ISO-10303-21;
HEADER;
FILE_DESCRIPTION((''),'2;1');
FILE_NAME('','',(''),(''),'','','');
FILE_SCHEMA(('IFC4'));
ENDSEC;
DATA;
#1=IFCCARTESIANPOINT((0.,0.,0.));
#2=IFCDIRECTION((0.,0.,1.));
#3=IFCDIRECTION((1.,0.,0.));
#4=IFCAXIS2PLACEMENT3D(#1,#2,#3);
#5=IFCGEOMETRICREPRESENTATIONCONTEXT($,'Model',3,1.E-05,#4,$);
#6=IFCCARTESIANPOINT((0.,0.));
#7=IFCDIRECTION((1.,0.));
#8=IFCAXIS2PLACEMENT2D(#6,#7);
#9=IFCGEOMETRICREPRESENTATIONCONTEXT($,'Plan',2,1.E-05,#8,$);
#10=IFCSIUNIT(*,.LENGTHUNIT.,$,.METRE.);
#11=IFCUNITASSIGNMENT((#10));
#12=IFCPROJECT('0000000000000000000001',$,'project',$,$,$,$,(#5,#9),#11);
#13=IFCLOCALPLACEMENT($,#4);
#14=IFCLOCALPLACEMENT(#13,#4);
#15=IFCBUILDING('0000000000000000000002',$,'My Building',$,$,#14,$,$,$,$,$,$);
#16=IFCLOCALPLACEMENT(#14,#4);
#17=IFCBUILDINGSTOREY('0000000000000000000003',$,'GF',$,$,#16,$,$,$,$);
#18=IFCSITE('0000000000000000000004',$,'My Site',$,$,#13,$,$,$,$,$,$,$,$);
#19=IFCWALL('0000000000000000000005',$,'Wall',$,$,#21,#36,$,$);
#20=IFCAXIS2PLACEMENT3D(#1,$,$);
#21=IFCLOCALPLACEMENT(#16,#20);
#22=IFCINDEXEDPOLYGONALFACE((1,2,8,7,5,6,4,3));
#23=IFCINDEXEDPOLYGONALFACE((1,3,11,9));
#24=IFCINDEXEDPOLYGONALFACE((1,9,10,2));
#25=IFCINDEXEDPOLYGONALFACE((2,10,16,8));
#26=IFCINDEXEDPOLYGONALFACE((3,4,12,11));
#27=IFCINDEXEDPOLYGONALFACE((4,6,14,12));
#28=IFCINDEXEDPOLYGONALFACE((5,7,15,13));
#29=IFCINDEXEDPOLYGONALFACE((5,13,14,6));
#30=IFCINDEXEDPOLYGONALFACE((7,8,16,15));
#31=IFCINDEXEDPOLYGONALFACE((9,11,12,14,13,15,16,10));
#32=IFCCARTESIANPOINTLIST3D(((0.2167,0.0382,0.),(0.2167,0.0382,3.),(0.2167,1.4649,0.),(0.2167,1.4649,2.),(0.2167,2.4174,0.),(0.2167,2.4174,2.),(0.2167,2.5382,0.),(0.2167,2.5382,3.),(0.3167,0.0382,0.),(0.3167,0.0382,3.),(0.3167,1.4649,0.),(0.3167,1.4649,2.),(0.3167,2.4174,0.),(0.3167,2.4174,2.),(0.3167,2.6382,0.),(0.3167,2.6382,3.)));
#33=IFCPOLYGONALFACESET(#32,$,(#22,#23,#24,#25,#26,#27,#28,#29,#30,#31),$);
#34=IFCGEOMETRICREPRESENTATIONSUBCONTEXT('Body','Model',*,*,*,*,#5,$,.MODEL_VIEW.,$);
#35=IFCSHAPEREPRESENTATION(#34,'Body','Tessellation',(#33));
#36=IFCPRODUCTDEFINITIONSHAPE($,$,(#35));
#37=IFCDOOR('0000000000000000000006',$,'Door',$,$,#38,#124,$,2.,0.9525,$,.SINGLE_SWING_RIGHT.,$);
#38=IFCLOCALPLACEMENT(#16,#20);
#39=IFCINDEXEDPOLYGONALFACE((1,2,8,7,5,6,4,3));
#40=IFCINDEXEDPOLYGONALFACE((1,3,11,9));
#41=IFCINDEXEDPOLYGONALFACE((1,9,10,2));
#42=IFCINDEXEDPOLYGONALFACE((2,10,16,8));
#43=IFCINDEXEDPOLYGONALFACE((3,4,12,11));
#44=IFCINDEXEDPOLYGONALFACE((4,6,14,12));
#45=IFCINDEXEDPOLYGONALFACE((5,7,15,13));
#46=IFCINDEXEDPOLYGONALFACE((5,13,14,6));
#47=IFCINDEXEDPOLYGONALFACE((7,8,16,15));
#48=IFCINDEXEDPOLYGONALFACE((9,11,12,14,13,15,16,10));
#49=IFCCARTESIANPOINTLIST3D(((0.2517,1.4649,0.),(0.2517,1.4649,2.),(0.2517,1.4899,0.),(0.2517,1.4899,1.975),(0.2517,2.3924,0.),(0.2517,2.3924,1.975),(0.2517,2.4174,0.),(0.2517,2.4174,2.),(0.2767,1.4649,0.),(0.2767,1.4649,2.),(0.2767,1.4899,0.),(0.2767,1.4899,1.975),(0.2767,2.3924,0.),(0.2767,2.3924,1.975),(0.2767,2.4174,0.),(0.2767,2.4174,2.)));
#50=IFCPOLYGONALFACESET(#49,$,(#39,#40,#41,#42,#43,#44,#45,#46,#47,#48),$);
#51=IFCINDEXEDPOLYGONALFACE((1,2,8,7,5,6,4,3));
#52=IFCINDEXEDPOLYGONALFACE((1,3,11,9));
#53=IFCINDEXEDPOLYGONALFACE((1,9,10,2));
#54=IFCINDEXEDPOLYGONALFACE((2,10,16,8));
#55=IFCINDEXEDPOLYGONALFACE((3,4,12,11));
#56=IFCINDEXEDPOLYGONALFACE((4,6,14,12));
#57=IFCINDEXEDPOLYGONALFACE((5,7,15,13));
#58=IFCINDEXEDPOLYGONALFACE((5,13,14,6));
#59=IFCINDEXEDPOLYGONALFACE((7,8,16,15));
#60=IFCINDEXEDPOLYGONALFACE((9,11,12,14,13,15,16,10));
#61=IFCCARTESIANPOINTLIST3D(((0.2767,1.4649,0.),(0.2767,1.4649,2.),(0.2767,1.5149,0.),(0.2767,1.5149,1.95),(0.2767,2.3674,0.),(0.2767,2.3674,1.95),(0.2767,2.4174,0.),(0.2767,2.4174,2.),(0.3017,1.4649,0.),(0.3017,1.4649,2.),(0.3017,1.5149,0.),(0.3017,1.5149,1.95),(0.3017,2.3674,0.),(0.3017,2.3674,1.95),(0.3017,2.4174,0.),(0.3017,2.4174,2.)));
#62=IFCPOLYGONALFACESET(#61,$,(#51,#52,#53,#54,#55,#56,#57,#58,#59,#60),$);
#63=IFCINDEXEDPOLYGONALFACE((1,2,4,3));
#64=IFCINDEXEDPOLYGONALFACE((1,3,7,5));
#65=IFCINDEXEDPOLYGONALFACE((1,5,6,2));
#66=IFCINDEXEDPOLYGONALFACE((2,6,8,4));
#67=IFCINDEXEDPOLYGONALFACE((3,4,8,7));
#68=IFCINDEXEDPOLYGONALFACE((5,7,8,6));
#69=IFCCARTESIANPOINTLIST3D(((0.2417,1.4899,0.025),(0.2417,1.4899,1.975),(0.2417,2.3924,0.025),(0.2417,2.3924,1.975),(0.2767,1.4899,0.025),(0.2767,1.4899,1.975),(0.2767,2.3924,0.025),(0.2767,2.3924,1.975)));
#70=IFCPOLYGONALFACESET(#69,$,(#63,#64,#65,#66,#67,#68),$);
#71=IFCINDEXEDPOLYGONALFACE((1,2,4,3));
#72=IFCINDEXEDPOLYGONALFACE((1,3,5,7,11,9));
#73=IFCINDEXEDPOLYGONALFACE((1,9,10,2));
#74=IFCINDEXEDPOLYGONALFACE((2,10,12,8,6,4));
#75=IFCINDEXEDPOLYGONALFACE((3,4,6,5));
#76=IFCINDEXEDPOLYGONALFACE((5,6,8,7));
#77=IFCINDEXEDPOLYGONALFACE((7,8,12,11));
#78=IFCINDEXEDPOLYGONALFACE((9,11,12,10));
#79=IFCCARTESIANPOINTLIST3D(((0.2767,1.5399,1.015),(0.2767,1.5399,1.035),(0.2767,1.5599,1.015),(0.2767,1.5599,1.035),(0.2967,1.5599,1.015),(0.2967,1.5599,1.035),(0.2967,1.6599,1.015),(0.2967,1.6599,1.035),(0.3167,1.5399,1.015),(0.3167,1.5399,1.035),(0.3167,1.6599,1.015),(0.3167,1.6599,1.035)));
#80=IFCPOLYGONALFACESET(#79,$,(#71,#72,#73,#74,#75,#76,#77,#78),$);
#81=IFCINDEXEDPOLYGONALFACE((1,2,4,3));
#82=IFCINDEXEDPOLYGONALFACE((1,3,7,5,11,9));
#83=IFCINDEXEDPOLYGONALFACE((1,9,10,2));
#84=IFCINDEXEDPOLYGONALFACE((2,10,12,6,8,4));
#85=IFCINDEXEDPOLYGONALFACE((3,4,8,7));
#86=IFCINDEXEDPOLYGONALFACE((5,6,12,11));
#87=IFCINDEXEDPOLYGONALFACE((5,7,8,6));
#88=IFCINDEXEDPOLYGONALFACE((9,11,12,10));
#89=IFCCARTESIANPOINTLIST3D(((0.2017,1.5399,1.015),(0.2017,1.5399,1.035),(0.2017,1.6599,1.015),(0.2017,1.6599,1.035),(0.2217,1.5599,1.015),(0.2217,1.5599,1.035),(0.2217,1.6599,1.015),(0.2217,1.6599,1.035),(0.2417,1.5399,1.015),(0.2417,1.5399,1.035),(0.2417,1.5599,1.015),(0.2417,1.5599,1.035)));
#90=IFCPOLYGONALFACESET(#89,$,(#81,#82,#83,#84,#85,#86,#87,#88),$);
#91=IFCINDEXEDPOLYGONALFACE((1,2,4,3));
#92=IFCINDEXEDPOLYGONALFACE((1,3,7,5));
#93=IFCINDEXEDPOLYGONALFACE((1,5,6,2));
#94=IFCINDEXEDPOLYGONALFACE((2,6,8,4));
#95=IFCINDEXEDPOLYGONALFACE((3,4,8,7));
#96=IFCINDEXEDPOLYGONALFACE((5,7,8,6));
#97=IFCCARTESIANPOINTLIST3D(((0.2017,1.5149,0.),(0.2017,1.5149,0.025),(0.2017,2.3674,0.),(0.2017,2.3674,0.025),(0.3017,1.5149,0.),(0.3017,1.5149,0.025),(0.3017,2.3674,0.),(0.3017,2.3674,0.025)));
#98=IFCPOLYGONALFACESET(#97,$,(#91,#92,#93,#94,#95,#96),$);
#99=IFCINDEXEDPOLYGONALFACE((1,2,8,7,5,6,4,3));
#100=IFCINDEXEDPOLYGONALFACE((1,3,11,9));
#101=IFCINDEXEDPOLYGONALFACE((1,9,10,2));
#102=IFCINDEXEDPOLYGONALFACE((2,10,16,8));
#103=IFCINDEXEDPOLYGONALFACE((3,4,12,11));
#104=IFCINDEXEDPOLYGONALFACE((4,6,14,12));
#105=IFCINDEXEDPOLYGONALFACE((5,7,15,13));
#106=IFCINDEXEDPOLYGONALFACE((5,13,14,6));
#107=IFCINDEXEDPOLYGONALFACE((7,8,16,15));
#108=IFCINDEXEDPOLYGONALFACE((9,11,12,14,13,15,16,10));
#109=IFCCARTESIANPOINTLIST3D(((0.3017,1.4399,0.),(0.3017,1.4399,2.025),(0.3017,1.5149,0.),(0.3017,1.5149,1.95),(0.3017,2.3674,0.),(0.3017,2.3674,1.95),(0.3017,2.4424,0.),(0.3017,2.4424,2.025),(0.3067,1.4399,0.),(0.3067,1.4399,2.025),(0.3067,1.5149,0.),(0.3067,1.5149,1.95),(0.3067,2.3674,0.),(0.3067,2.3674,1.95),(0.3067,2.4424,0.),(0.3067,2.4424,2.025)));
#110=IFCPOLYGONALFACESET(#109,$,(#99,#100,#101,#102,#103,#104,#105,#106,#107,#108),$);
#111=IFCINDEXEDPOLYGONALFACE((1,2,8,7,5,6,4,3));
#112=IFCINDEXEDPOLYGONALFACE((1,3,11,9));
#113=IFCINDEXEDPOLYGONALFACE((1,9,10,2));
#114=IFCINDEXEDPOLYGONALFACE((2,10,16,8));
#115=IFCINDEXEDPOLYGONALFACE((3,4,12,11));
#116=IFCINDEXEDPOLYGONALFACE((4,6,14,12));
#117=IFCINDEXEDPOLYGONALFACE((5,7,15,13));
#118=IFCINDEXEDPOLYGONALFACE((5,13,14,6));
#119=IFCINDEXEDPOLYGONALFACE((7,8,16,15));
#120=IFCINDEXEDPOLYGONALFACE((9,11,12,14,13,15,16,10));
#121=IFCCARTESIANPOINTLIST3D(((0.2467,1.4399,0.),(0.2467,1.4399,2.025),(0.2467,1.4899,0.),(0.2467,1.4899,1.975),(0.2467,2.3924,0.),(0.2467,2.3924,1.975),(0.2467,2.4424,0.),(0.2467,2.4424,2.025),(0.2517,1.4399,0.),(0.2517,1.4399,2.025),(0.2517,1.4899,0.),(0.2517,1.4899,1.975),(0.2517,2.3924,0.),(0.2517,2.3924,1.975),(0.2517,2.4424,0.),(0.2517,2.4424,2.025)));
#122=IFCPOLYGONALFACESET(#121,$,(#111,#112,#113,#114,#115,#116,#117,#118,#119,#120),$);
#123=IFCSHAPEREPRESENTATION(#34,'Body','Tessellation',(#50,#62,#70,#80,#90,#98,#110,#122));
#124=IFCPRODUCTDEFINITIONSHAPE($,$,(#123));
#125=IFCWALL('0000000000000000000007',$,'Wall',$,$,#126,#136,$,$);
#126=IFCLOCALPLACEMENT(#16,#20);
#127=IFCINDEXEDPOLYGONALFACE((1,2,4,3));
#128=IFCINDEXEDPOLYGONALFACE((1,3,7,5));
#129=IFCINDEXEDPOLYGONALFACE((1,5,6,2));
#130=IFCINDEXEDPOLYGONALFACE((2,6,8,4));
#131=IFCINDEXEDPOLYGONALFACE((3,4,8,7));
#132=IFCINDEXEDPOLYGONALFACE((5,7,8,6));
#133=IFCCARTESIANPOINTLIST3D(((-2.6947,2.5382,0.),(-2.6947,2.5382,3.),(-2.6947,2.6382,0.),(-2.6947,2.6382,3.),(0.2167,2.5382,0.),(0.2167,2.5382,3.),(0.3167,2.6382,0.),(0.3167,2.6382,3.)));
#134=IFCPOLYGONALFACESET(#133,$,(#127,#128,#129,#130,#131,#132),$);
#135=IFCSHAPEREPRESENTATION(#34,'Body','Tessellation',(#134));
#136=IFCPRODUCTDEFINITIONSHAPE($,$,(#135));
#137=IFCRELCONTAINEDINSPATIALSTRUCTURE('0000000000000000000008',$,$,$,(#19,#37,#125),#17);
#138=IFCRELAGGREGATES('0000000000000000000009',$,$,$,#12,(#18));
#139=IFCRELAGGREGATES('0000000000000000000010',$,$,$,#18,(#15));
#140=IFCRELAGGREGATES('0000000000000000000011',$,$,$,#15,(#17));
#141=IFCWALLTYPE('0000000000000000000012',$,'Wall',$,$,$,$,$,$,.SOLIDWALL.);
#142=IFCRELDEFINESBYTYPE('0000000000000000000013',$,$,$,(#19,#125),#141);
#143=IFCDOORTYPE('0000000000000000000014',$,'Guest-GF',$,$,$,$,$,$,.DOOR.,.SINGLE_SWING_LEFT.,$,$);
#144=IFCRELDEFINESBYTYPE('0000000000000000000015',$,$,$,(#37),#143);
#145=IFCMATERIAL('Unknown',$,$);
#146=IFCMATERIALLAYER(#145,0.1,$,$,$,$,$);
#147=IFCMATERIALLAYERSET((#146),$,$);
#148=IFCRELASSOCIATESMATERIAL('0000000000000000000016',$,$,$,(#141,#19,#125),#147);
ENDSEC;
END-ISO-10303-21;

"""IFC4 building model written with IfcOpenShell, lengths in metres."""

from ifc_helpers import new_model, entity, si_unit, frame, origin_with_axes, origin_2d_with_axis, place, context, subcontext, project, spatial, line, indexed_curve, outline, extrude, shape, source, transform, mapped, material, layer, layer_set, layer_usage, type_object, type_shapes, element, fill, save


model = new_model("IFC4")

# Units and contexts
model_context = context("Model", 3, precision=1e-05, world=origin_with_axes())
plan_context = context("Plan", 2, precision=1e-05, world=origin_2d_with_axis())
body_context_1 = subcontext(model_context, "Body", "Model", "MODEL_VIEW")
body_context_2 = subcontext(plan_context, "Body", "Plan", "PLAN_VIEW")
ifc_project = project(units=[si_unit("LENGTHUNIT", "METRE")], contexts=[model_context, plan_context])

# Site, building, storey
site_placement = place(None, origin_with_axes())
site = spatial("IfcSite", under=ifc_project, at=site_placement, Name="My Site")
building_placement = place(site_placement, origin_with_axes())
building = spatial("IfcBuilding", under=site, at=building_placement, Name="My Building")
storey_placement = place(building_placement, origin_with_axes())
storey = spatial("IfcBuildingStorey", under=building, at=storey_placement, Name="GF")

# Shared definitions
ifc_material_1 = material(Name="Unknown")

# Shared definitions
ifc_layer_1 = layer(ifc_material_1, 0.1)
ifc_layer_set_1 = layer_set([ifc_layer_1])
wall_type = type_object("IfcWallType", Name="Wall", PredefinedType="SOLIDWALL", material=ifc_layer_set_1)

# Wall, opening, door
ifc_layer_usage_1 = layer_usage(ifc_layer_set_1, "AXIS2", "POSITIVE", 0.0)
wall_1_placement = place(storey_placement, frame((0.3167, 0.0382, 0.0), z_axis=(0.0, 0.0, 1.0), x_axis=(0.0, 1.0, 0.0)))
wall_1 = element("IfcWall", 1, at=wall_1_placement, inside=storey, type_object=wall_type, material=ifc_layer_usage_1, Name="Wall", context=body_context_1, shape_type="SweptSolid", body=[
    extrude(outline(indexed_curve([(0.0, 0.0), (0.0, 0.1), (2.5, 0.1), (2.6, 0.0)], segments=[line(1, 2, 3, 4, 1)])), origin_with_axes(), (0.0, 0.0, 1.0), 3.0),
])
shared_shape_1 = source(origin_with_axes(), body_context_1, "Body", "SweptSolid", [
    extrude(outline(indexed_curve([(0.0, 0.0), (0.9525, 0.0), (0.9525, 2.0), (0.0, 2.0)], segments=[line(1, 2, 3, 4, 1)])), frame((0.0, -0.6, 0.0), z_axis=(0.0, -1.0, 0.0), x_axis=(1.0, 0.0, 0.0)), (0.0, 0.0, -1.0), 1.2),
])
opening_1_placement = place(wall_1_placement, frame((1.4267, 0.015, 0.0), z_axis=(0.0, 0.0, 1.0), x_axis=(1.0, 0.0, 0.0)))
opening_1 = element("IfcOpeningElement", 2, at=opening_1_placement, cuts=wall_1, PredefinedType="OPENING", context=body_context_1, shape_type="MappedRepresentation", body=[
    mapped(shared_shape_1, transform((0.0, 0.0, 0.0), x_axis=(1.0, 0.0, 0.0), y_axis=(0.0, 1.0, 0.0), z_axis=(0.0, 0.0, 1.0), scale=1.0)),
])
door_type_1 = type_object("IfcDoorType", Name="Guest-GF", OperationType="SINGLE_SWING_LEFT", PredefinedType="DOOR")
shared_shape_2 = source(origin_with_axes(), body_context_1, "Body", "SweptSolid", [
    extrude(outline(indexed_curve([(0.0, 0.0), (0.0, 2.0), (0.9525, 2.0), (0.9525, 0.0), (0.9275, 0.0), (0.9275, 1.975), (0.025, 1.975), (0.025, 0.0)], segments=[line(1, 2, 3, 4, 5, 6, 7, 8, 1)])), frame((0.0, 0.025, 0.0), z_axis=(0.0, -1.0, 0.0), x_axis=(1.0, 0.0, 0.0)), (0.0, 0.0, -1.0), 0.025),
    extrude(outline(indexed_curve([(0.0, 0.0), (0.0, 2.0), (0.9525, 2.0), (0.9525, 0.0), (0.9025, 0.0), (0.9025, 1.95), (0.05, 1.95), (0.05, 0.0)], segments=[line(1, 2, 3, 4, 5, 6, 7, 8, 1)])), frame((0.0, 0.0, 0.0), z_axis=(0.0, -1.0, 0.0), x_axis=(1.0, 0.0, 0.0)), (0.0, 0.0, -1.0), 0.025),
    extrude(outline(indexed_curve([(0.0, 0.0), (0.9025, 0.0), (0.9025, 0.035), (0.0, 0.035)], segments=[line(1, 2, 3, 4, 1)])), frame((0.025, 0.025, 0.025), z_axis=(0.0, 0.0, 1.0), x_axis=(1.0, 0.0, 0.0)), (0.0, 0.0, 1.0), 1.95),
    extrude(outline(indexed_curve([(0.0, 0.0), (0.0, -0.04), (0.12, -0.04), (0.12, -0.02), (0.02, -0.02), (0.02, 0.0)], segments=[line(1, 2, 3, 4, 5, 6, 1)])), frame((0.075, 0.025, 1.015), z_axis=(0.0, 0.0, 1.0), x_axis=(1.0, 0.0, 0.0)), (0.0, 0.0, 1.0), 0.02),
    extrude(outline(indexed_curve([(0.0, 0.0), (0.0, 0.04), (0.12, 0.04), (0.12, 0.02), (0.02, 0.02), (0.02, 0.0)], segments=[line(1, 2, 3, 4, 5, 6, 1)])), frame((0.075, 0.06, 1.015), z_axis=(0.0, 0.0, 1.0), x_axis=(1.0, 0.0, 0.0)), (0.0, 0.0, 1.0), 0.02),
    extrude(outline(indexed_curve([(0.0, 0.0), (0.8525, 0.0), (0.8525, 0.1), (0.0, 0.1)], segments=[line(1, 2, 3, 4, 1)])), frame((0.05, 0.0, 0.0), z_axis=(0.0, 0.0, 1.0), x_axis=(1.0, 0.0, 0.0)), (0.0, 0.0, 1.0), 0.025),
    extrude(outline(indexed_curve([(0.0, 0.0), (0.0, 2.025), (1.0025, 2.025), (1.0025, 0.0), (0.9275, 0.0), (0.9275, 1.95), (0.075, 1.95), (0.075, 0.0)], segments=[line(1, 2, 3, 4, 5, 6, 7, 8, 1)])), frame((-0.025, -0.005, 0.0), z_axis=(0.0, -1.0, 0.0), x_axis=(1.0, 0.0, 0.0)), (0.0, 0.0, -1.0), 0.005),
    extrude(outline(indexed_curve([(0.0, 0.0), (0.0, 2.025), (1.0025, 2.025), (1.0025, 0.0), (0.9525, 0.0), (0.9525, 1.975), (0.05, 1.975), (0.05, 0.0)], segments=[line(1, 2, 3, 4, 5, 6, 7, 8, 1)])), frame((-0.025, 0.05, 0.0), z_axis=(0.0, -1.0, 0.0), x_axis=(1.0, 0.0, 0.0)), (0.0, 0.0, -1.0), 0.005),
])
shared_shape_3 = source(origin_with_axes(), body_context_2, "Body", "Curve2D", [
    entity("IfcIndexedPolyCurve", entity("IfcCartesianPointList2D", [[0.0, 0.0], [0.0, 0.05], [0.025, 0.05], [0.025, 0.025], [0.05, 0.025], [0.05, 0.0]]), [entity("IfcLineIndex", [1, 2, 3, 4, 5, 6, 1])]),
    entity("IfcIndexedPolyCurve", entity("IfcCartesianPointList2D", [[0.9525, 0.0], [0.9525, 0.05], [0.9275, 0.05], [0.9275, 0.025], [0.9025, 0.025], [0.9025, 0.0]]), [entity("IfcLineIndex", [1, 2, 3, 4, 5, 6, 1])]),
    entity("IfcTrimmedCurve", entity("IfcEllipse", entity("IfcAxis2Placement2D", entity("IfcCartesianPoint", [0.8925, 0.05]), entity("IfcDirection", [1.0, 0.0])), 0.8675, 0.9025), [entity("IfcCartesianPoint", [0.8925, 0.9525])], [entity("IfcCartesianPoint", [0.025, 0.05])], True, "CARTESIAN"),
    entity("IfcIndexedPolyCurve", entity("IfcCartesianPointList2D", [[0.9275, 0.05], [0.8925, 0.05], [0.8925, 0.9525], [0.9275, 0.9525]]), [entity("IfcLineIndex", [1, 2, 3, 4, 1])]),
])
type_shapes(door_type_1, [shared_shape_2, shared_shape_3])
door_1_placement = place(opening_1_placement, frame((0.0, 0.0, 0.0), z_axis=(0.0, 0.0, 1.0), x_axis=(1.0, 0.0, 0.0)))
door_1 = element("IfcDoor", 3, at=door_1_placement, inside=storey, type_object=door_type_1, Name="Door", OperationType="SINGLE_SWING_RIGHT", OverallHeight=2.0, OverallWidth=0.9525, shapes=[
    shape(body_context_1, "Body", "MappedRepresentation", [mapped(shared_shape_2, transform((0.0, 0.0, 0.0), x_axis=(1.0, 0.0, 0.0), y_axis=(0.0, 1.0, 0.0), z_axis=(0.0, 0.0, 1.0), scale=1.0))]),
    shape(body_context_2, "Body", "MappedRepresentation", [mapped(shared_shape_3, transform((0.0, 0.0, 0.0), x_axis=(1.0, 0.0, 0.0), y_axis=(0.0, 1.0, 0.0), z_axis=(0.0, 0.0, 1.0), scale=1.0))]),
])
fill(opening_1, door_1)

# Wall
ifc_layer_usage_2 = layer_usage(ifc_layer_set_1, "AXIS2", "POSITIVE", 0.0)
wall_2_placement = place(storey_placement, frame((0.3167, 2.6382, 0.0), z_axis=(0.0, 0.0, 1.0), x_axis=(-1.0, 0.0, 0.0)))
element("IfcWall", 4, at=wall_2_placement, inside=storey, type_object=wall_type, material=ifc_layer_usage_2, Name="Wall", context=body_context_1, shape_type="SweptSolid", body=[
    extrude(outline(indexed_curve([(0.0, 0.0), (0.1, 0.1), (3.0114, 0.1), (3.0114, 0.0)], segments=[line(1, 2, 3, 4, 1)])), origin_with_axes(), (0.0, 0.0, 1.0), 3.0),
])

save(model, "model.ifc")
